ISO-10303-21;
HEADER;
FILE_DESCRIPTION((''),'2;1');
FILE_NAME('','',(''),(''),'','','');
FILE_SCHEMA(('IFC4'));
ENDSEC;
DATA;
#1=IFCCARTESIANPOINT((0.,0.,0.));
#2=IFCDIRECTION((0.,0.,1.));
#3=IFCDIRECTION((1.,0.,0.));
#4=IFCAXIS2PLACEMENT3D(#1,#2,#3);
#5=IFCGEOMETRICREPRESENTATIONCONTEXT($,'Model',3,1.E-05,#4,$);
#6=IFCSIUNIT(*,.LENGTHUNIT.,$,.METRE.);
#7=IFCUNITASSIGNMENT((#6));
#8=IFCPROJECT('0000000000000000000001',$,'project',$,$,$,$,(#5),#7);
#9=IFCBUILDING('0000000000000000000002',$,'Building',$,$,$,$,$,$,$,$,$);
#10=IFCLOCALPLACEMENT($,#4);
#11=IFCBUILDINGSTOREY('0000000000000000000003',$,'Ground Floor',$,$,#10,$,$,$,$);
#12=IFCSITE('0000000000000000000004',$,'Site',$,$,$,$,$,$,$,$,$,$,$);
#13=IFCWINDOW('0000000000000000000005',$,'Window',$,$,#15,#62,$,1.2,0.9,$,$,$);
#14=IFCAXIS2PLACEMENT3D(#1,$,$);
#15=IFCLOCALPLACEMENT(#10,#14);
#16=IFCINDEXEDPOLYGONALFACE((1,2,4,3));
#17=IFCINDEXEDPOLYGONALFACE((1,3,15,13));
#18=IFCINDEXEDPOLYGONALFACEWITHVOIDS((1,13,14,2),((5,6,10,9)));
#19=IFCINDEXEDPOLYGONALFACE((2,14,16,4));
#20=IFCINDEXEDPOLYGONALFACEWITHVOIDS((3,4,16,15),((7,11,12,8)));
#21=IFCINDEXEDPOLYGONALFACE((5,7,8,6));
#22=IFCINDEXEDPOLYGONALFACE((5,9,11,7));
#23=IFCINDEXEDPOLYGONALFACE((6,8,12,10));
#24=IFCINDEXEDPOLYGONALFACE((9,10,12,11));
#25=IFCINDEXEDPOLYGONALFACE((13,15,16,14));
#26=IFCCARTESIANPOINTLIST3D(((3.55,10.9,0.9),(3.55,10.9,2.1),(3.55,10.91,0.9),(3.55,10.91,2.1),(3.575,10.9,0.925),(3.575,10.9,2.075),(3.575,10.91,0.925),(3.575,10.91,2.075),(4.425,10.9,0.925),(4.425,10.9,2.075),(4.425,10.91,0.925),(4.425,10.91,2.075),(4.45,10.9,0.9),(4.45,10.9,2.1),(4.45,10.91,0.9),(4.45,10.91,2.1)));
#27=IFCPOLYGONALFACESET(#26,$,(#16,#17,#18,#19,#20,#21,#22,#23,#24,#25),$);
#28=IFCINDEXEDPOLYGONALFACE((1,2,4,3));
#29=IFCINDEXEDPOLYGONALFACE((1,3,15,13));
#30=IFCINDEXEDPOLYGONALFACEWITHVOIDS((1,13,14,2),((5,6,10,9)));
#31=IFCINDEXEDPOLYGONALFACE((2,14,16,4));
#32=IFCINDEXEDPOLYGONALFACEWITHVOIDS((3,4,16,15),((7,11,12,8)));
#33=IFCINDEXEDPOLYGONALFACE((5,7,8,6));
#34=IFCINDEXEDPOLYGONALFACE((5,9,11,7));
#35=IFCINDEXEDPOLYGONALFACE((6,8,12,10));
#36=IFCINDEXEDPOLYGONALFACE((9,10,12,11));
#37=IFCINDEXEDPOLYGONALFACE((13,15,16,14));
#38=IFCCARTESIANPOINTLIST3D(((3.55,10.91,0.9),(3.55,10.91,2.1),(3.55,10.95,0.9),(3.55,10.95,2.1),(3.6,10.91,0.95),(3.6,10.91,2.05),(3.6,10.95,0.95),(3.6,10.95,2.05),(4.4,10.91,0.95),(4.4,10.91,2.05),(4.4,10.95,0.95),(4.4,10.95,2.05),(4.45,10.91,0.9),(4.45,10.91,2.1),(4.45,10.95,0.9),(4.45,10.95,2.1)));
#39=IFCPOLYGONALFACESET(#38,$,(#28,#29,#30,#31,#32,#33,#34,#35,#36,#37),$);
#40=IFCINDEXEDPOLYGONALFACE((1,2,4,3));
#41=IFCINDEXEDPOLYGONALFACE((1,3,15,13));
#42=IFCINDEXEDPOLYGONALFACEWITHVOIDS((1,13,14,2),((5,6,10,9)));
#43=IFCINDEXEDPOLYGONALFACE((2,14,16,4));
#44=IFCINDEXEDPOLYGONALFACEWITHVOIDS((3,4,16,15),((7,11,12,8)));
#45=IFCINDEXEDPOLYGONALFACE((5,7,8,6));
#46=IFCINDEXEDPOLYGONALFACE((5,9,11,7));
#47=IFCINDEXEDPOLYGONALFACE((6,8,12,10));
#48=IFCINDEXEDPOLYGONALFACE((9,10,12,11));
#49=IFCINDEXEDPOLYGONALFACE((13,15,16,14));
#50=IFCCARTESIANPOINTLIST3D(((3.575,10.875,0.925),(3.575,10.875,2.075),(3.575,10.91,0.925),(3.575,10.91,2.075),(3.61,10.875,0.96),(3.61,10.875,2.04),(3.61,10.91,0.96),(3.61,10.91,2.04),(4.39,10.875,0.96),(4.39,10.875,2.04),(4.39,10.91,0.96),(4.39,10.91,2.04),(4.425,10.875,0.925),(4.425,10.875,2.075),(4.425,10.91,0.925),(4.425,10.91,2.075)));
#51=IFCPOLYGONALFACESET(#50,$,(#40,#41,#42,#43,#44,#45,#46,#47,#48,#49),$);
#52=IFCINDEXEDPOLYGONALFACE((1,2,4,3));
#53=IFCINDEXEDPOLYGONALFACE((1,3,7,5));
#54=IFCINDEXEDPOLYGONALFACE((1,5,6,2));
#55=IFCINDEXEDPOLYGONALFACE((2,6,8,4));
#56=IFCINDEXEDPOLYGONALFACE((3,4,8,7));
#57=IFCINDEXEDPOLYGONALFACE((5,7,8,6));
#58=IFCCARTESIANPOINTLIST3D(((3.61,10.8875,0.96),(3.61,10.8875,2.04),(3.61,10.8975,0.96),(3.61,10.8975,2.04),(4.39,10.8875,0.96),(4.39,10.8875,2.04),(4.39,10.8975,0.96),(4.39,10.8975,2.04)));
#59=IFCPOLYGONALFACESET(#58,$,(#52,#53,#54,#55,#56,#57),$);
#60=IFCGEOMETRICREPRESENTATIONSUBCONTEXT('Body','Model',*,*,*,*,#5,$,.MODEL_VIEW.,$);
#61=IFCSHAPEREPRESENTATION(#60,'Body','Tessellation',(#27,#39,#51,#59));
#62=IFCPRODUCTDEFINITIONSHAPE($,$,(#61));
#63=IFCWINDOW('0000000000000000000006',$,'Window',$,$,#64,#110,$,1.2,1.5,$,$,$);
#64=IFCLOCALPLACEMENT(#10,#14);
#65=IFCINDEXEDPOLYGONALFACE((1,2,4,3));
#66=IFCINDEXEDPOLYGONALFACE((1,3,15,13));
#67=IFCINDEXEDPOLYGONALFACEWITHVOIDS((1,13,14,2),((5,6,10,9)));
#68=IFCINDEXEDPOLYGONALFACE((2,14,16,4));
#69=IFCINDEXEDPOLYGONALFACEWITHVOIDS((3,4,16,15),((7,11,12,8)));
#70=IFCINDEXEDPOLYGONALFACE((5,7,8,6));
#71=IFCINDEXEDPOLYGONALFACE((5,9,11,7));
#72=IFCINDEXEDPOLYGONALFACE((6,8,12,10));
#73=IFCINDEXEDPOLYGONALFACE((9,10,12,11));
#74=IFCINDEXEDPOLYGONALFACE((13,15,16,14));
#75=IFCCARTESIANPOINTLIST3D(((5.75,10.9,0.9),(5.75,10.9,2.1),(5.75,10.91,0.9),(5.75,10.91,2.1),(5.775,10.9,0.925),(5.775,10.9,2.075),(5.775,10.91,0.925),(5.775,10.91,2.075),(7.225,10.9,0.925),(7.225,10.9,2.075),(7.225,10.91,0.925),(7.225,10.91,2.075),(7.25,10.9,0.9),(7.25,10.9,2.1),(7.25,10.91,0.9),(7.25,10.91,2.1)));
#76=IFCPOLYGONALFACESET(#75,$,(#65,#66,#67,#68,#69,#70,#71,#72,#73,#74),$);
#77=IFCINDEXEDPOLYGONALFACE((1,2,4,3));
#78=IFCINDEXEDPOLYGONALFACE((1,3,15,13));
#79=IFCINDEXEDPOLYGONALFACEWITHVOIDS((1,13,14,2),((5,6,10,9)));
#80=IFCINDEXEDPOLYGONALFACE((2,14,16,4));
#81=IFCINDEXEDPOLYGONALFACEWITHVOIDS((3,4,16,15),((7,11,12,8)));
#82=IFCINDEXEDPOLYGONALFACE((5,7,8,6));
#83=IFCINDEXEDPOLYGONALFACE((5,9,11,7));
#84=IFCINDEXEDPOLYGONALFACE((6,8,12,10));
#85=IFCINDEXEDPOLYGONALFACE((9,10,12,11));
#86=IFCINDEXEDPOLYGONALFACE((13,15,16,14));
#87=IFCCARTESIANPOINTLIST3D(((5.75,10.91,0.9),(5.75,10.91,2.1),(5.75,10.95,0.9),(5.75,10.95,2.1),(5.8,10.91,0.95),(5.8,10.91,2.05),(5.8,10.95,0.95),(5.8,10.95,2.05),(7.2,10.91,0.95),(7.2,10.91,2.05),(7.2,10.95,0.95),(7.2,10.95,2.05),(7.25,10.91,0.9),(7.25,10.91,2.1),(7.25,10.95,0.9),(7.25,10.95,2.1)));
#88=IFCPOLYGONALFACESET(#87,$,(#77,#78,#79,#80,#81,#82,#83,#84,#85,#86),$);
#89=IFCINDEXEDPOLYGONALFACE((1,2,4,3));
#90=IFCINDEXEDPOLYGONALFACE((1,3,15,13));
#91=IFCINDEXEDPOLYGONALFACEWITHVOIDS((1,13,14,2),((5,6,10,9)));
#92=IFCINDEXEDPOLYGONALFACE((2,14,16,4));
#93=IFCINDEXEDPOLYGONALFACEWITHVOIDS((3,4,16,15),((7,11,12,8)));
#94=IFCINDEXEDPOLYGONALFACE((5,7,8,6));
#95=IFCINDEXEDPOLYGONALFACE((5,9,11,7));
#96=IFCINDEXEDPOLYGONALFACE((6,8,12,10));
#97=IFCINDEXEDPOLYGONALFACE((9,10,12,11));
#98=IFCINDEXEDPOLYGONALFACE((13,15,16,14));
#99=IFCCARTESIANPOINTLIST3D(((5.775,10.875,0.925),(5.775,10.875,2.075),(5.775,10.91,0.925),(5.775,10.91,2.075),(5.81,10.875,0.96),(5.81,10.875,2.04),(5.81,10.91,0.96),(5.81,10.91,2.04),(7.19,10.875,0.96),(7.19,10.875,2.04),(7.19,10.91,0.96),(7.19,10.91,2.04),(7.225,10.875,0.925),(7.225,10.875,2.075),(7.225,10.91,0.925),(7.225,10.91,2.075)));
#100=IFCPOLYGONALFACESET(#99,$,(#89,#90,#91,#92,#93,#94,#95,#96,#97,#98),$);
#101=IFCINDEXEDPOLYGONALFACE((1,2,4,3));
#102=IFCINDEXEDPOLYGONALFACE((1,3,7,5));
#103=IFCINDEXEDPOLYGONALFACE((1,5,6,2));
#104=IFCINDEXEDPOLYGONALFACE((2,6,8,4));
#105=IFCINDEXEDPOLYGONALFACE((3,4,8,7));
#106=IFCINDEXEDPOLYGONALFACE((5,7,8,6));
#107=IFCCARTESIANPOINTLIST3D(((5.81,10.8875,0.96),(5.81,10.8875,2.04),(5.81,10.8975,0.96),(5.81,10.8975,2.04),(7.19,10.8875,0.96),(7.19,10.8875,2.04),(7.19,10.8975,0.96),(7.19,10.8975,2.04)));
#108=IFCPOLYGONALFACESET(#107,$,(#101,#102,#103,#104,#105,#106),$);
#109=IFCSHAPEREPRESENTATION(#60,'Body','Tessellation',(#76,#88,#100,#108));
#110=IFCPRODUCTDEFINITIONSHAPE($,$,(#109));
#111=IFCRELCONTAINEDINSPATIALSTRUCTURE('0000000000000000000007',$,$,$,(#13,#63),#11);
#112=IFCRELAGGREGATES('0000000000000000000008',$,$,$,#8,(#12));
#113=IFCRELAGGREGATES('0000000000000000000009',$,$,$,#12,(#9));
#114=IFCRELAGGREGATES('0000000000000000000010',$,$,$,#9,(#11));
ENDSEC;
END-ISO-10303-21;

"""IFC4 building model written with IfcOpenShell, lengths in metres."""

from ifc_helpers import new_model, si_unit, frame, origin_with_axes, place, context, subcontext, project, spatial, line, indexed_curve, outline, extrude, element, save


model = new_model("IFC4")

# Units and contexts
model_context = context("Model", 3, precision=1e-05, world=origin_with_axes())
body_context = subcontext(model_context, "Body", "Model", "MODEL_VIEW")
ifc_project = project(units=[si_unit("LENGTHUNIT", "METRE")], contexts=[model_context])

# Site, building, storey
site = spatial("IfcSite", under=ifc_project, Name="Site")
building = spatial("IfcBuilding", under=site, Name="Building")
storey_placement = place(None, origin_with_axes())
storey = spatial("IfcBuildingStorey", under=building, at=storey_placement, Name="Ground Floor")

# Windows
for number, where, z_axis, x_axis, name in (
    (1, (4.45, 11.0, 0.9), (0.0, 0.0, 1.0), (-1.0, 0.0, 0.0), "Window"),
):
    element("IfcWindow", number, at=place(storey_placement, frame(where, z_axis=z_axis, x_axis=x_axis)), inside=storey, Name=name, OverallHeight=1.2, OverallWidth=0.9, context=body_context, shape_type="SweptSolid", body=[
        extrude(outline(indexed_curve([(0.0, 0.0), (0.9, 0.0), (0.9, 1.2), (0.0, 1.2)], segments=[line(1, 2, 3, 4, 1)]), holes=[indexed_curve([(0.025, 0.025), (0.875, 0.025), (0.875, 1.175), (0.025, 1.175)], segments=[line(1, 2, 3, 4, 1)])]), frame((0.0, 0.09, 0.0), z_axis=(0.0, -1.0, 0.0), x_axis=(1.0, 0.0, 0.0)), (0.0, 0.0, -1.0), 0.01),
        extrude(outline(indexed_curve([(0.0, 0.0), (0.9, 0.0), (0.9, 1.2), (0.0, 1.2)], segments=[line(1, 2, 3, 4, 1)]), holes=[indexed_curve([(0.05, 0.05), (0.85, 0.05), (0.85, 1.15), (0.05, 1.15)], segments=[line(1, 2, 3, 4, 1)])]), frame((0.0, 0.05, 0.0), z_axis=(0.0, -1.0, 0.0), x_axis=(1.0, 0.0, 0.0)), (0.0, 0.0, -1.0), 0.04),
        extrude(outline(indexed_curve([(0.0, 0.0), (0.85, 0.0), (0.85, 1.15), (0.0, 1.15)], segments=[line(1, 2, 3, 4, 1)]), holes=[indexed_curve([(0.035, 0.035), (0.815, 0.035), (0.815, 1.115), (0.035, 1.115)], segments=[line(1, 2, 3, 4, 1)])]), frame((0.025, 0.09, 0.025), z_axis=(0.0, -1.0, 0.0), x_axis=(1.0, 0.0, 0.0)), (0.0, 0.0, -1.0), 0.035),
        extrude(outline(indexed_curve([(0.035, 0.035), (0.815, 0.035), (0.815, 1.115), (0.035, 1.115)], segments=[line(1, 2, 3, 4, 1)])), frame((0.025, 0.1025, 0.025), z_axis=(0.0, -1.0, 0.0), x_axis=(1.0, 0.0, 0.0)), (0.0, 0.0, -1.0), 0.01),
    ])
window_1_placement = place(storey_placement, frame((7.25, 11.0, 0.9), z_axis=(0.0, 0.0, 1.0), x_axis=(-1.0, 0.0, 0.0)))
element("IfcWindow", 2, at=window_1_placement, inside=storey, Name="Window", OverallHeight=1.2, OverallWidth=1.5, context=body_context, shape_type="SweptSolid", body=[
    extrude(outline(indexed_curve([(0.0, 0.0), (1.5, 0.0), (1.5, 1.2), (0.0, 1.2)], segments=[line(1, 2, 3, 4, 1)]), holes=[indexed_curve([(0.025, 0.025), (1.475, 0.025), (1.475, 1.175), (0.025, 1.175)], segments=[line(1, 2, 3, 4, 1)])]), frame((0.0, 0.09, 0.0), z_axis=(0.0, -1.0, 0.0), x_axis=(1.0, 0.0, 0.0)), (0.0, 0.0, -1.0), 0.01),
    extrude(outline(indexed_curve([(0.0, 0.0), (1.5, 0.0), (1.5, 1.2), (0.0, 1.2)], segments=[line(1, 2, 3, 4, 1)]), holes=[indexed_curve([(0.05, 0.05), (1.45, 0.05), (1.45, 1.15), (0.05, 1.15)], segments=[line(1, 2, 3, 4, 1)])]), frame((0.0, 0.05, 0.0), z_axis=(0.0, -1.0, 0.0), x_axis=(1.0, 0.0, 0.0)), (0.0, 0.0, -1.0), 0.04),
    extrude(outline(indexed_curve([(0.0, 0.0), (1.45, 0.0), (1.45, 1.15), (0.0, 1.15)], segments=[line(1, 2, 3, 4, 1)]), holes=[indexed_curve([(0.035, 0.035), (1.415, 0.035), (1.415, 1.115), (0.035, 1.115)], segments=[line(1, 2, 3, 4, 1)])]), frame((0.025, 0.09, 0.025), z_axis=(0.0, -1.0, 0.0), x_axis=(1.0, 0.0, 0.0)), (0.0, 0.0, -1.0), 0.035),
    extrude(outline(indexed_curve([(0.035, 0.035), (1.415, 0.035), (1.415, 1.115), (0.035, 1.115)], segments=[line(1, 2, 3, 4, 1)])), frame((0.025, 0.1025, 0.025), z_axis=(0.0, -1.0, 0.0), x_axis=(1.0, 0.0, 0.0)), (0.0, 0.0, -1.0), 0.01),
])

save(model, "model.ifc")
